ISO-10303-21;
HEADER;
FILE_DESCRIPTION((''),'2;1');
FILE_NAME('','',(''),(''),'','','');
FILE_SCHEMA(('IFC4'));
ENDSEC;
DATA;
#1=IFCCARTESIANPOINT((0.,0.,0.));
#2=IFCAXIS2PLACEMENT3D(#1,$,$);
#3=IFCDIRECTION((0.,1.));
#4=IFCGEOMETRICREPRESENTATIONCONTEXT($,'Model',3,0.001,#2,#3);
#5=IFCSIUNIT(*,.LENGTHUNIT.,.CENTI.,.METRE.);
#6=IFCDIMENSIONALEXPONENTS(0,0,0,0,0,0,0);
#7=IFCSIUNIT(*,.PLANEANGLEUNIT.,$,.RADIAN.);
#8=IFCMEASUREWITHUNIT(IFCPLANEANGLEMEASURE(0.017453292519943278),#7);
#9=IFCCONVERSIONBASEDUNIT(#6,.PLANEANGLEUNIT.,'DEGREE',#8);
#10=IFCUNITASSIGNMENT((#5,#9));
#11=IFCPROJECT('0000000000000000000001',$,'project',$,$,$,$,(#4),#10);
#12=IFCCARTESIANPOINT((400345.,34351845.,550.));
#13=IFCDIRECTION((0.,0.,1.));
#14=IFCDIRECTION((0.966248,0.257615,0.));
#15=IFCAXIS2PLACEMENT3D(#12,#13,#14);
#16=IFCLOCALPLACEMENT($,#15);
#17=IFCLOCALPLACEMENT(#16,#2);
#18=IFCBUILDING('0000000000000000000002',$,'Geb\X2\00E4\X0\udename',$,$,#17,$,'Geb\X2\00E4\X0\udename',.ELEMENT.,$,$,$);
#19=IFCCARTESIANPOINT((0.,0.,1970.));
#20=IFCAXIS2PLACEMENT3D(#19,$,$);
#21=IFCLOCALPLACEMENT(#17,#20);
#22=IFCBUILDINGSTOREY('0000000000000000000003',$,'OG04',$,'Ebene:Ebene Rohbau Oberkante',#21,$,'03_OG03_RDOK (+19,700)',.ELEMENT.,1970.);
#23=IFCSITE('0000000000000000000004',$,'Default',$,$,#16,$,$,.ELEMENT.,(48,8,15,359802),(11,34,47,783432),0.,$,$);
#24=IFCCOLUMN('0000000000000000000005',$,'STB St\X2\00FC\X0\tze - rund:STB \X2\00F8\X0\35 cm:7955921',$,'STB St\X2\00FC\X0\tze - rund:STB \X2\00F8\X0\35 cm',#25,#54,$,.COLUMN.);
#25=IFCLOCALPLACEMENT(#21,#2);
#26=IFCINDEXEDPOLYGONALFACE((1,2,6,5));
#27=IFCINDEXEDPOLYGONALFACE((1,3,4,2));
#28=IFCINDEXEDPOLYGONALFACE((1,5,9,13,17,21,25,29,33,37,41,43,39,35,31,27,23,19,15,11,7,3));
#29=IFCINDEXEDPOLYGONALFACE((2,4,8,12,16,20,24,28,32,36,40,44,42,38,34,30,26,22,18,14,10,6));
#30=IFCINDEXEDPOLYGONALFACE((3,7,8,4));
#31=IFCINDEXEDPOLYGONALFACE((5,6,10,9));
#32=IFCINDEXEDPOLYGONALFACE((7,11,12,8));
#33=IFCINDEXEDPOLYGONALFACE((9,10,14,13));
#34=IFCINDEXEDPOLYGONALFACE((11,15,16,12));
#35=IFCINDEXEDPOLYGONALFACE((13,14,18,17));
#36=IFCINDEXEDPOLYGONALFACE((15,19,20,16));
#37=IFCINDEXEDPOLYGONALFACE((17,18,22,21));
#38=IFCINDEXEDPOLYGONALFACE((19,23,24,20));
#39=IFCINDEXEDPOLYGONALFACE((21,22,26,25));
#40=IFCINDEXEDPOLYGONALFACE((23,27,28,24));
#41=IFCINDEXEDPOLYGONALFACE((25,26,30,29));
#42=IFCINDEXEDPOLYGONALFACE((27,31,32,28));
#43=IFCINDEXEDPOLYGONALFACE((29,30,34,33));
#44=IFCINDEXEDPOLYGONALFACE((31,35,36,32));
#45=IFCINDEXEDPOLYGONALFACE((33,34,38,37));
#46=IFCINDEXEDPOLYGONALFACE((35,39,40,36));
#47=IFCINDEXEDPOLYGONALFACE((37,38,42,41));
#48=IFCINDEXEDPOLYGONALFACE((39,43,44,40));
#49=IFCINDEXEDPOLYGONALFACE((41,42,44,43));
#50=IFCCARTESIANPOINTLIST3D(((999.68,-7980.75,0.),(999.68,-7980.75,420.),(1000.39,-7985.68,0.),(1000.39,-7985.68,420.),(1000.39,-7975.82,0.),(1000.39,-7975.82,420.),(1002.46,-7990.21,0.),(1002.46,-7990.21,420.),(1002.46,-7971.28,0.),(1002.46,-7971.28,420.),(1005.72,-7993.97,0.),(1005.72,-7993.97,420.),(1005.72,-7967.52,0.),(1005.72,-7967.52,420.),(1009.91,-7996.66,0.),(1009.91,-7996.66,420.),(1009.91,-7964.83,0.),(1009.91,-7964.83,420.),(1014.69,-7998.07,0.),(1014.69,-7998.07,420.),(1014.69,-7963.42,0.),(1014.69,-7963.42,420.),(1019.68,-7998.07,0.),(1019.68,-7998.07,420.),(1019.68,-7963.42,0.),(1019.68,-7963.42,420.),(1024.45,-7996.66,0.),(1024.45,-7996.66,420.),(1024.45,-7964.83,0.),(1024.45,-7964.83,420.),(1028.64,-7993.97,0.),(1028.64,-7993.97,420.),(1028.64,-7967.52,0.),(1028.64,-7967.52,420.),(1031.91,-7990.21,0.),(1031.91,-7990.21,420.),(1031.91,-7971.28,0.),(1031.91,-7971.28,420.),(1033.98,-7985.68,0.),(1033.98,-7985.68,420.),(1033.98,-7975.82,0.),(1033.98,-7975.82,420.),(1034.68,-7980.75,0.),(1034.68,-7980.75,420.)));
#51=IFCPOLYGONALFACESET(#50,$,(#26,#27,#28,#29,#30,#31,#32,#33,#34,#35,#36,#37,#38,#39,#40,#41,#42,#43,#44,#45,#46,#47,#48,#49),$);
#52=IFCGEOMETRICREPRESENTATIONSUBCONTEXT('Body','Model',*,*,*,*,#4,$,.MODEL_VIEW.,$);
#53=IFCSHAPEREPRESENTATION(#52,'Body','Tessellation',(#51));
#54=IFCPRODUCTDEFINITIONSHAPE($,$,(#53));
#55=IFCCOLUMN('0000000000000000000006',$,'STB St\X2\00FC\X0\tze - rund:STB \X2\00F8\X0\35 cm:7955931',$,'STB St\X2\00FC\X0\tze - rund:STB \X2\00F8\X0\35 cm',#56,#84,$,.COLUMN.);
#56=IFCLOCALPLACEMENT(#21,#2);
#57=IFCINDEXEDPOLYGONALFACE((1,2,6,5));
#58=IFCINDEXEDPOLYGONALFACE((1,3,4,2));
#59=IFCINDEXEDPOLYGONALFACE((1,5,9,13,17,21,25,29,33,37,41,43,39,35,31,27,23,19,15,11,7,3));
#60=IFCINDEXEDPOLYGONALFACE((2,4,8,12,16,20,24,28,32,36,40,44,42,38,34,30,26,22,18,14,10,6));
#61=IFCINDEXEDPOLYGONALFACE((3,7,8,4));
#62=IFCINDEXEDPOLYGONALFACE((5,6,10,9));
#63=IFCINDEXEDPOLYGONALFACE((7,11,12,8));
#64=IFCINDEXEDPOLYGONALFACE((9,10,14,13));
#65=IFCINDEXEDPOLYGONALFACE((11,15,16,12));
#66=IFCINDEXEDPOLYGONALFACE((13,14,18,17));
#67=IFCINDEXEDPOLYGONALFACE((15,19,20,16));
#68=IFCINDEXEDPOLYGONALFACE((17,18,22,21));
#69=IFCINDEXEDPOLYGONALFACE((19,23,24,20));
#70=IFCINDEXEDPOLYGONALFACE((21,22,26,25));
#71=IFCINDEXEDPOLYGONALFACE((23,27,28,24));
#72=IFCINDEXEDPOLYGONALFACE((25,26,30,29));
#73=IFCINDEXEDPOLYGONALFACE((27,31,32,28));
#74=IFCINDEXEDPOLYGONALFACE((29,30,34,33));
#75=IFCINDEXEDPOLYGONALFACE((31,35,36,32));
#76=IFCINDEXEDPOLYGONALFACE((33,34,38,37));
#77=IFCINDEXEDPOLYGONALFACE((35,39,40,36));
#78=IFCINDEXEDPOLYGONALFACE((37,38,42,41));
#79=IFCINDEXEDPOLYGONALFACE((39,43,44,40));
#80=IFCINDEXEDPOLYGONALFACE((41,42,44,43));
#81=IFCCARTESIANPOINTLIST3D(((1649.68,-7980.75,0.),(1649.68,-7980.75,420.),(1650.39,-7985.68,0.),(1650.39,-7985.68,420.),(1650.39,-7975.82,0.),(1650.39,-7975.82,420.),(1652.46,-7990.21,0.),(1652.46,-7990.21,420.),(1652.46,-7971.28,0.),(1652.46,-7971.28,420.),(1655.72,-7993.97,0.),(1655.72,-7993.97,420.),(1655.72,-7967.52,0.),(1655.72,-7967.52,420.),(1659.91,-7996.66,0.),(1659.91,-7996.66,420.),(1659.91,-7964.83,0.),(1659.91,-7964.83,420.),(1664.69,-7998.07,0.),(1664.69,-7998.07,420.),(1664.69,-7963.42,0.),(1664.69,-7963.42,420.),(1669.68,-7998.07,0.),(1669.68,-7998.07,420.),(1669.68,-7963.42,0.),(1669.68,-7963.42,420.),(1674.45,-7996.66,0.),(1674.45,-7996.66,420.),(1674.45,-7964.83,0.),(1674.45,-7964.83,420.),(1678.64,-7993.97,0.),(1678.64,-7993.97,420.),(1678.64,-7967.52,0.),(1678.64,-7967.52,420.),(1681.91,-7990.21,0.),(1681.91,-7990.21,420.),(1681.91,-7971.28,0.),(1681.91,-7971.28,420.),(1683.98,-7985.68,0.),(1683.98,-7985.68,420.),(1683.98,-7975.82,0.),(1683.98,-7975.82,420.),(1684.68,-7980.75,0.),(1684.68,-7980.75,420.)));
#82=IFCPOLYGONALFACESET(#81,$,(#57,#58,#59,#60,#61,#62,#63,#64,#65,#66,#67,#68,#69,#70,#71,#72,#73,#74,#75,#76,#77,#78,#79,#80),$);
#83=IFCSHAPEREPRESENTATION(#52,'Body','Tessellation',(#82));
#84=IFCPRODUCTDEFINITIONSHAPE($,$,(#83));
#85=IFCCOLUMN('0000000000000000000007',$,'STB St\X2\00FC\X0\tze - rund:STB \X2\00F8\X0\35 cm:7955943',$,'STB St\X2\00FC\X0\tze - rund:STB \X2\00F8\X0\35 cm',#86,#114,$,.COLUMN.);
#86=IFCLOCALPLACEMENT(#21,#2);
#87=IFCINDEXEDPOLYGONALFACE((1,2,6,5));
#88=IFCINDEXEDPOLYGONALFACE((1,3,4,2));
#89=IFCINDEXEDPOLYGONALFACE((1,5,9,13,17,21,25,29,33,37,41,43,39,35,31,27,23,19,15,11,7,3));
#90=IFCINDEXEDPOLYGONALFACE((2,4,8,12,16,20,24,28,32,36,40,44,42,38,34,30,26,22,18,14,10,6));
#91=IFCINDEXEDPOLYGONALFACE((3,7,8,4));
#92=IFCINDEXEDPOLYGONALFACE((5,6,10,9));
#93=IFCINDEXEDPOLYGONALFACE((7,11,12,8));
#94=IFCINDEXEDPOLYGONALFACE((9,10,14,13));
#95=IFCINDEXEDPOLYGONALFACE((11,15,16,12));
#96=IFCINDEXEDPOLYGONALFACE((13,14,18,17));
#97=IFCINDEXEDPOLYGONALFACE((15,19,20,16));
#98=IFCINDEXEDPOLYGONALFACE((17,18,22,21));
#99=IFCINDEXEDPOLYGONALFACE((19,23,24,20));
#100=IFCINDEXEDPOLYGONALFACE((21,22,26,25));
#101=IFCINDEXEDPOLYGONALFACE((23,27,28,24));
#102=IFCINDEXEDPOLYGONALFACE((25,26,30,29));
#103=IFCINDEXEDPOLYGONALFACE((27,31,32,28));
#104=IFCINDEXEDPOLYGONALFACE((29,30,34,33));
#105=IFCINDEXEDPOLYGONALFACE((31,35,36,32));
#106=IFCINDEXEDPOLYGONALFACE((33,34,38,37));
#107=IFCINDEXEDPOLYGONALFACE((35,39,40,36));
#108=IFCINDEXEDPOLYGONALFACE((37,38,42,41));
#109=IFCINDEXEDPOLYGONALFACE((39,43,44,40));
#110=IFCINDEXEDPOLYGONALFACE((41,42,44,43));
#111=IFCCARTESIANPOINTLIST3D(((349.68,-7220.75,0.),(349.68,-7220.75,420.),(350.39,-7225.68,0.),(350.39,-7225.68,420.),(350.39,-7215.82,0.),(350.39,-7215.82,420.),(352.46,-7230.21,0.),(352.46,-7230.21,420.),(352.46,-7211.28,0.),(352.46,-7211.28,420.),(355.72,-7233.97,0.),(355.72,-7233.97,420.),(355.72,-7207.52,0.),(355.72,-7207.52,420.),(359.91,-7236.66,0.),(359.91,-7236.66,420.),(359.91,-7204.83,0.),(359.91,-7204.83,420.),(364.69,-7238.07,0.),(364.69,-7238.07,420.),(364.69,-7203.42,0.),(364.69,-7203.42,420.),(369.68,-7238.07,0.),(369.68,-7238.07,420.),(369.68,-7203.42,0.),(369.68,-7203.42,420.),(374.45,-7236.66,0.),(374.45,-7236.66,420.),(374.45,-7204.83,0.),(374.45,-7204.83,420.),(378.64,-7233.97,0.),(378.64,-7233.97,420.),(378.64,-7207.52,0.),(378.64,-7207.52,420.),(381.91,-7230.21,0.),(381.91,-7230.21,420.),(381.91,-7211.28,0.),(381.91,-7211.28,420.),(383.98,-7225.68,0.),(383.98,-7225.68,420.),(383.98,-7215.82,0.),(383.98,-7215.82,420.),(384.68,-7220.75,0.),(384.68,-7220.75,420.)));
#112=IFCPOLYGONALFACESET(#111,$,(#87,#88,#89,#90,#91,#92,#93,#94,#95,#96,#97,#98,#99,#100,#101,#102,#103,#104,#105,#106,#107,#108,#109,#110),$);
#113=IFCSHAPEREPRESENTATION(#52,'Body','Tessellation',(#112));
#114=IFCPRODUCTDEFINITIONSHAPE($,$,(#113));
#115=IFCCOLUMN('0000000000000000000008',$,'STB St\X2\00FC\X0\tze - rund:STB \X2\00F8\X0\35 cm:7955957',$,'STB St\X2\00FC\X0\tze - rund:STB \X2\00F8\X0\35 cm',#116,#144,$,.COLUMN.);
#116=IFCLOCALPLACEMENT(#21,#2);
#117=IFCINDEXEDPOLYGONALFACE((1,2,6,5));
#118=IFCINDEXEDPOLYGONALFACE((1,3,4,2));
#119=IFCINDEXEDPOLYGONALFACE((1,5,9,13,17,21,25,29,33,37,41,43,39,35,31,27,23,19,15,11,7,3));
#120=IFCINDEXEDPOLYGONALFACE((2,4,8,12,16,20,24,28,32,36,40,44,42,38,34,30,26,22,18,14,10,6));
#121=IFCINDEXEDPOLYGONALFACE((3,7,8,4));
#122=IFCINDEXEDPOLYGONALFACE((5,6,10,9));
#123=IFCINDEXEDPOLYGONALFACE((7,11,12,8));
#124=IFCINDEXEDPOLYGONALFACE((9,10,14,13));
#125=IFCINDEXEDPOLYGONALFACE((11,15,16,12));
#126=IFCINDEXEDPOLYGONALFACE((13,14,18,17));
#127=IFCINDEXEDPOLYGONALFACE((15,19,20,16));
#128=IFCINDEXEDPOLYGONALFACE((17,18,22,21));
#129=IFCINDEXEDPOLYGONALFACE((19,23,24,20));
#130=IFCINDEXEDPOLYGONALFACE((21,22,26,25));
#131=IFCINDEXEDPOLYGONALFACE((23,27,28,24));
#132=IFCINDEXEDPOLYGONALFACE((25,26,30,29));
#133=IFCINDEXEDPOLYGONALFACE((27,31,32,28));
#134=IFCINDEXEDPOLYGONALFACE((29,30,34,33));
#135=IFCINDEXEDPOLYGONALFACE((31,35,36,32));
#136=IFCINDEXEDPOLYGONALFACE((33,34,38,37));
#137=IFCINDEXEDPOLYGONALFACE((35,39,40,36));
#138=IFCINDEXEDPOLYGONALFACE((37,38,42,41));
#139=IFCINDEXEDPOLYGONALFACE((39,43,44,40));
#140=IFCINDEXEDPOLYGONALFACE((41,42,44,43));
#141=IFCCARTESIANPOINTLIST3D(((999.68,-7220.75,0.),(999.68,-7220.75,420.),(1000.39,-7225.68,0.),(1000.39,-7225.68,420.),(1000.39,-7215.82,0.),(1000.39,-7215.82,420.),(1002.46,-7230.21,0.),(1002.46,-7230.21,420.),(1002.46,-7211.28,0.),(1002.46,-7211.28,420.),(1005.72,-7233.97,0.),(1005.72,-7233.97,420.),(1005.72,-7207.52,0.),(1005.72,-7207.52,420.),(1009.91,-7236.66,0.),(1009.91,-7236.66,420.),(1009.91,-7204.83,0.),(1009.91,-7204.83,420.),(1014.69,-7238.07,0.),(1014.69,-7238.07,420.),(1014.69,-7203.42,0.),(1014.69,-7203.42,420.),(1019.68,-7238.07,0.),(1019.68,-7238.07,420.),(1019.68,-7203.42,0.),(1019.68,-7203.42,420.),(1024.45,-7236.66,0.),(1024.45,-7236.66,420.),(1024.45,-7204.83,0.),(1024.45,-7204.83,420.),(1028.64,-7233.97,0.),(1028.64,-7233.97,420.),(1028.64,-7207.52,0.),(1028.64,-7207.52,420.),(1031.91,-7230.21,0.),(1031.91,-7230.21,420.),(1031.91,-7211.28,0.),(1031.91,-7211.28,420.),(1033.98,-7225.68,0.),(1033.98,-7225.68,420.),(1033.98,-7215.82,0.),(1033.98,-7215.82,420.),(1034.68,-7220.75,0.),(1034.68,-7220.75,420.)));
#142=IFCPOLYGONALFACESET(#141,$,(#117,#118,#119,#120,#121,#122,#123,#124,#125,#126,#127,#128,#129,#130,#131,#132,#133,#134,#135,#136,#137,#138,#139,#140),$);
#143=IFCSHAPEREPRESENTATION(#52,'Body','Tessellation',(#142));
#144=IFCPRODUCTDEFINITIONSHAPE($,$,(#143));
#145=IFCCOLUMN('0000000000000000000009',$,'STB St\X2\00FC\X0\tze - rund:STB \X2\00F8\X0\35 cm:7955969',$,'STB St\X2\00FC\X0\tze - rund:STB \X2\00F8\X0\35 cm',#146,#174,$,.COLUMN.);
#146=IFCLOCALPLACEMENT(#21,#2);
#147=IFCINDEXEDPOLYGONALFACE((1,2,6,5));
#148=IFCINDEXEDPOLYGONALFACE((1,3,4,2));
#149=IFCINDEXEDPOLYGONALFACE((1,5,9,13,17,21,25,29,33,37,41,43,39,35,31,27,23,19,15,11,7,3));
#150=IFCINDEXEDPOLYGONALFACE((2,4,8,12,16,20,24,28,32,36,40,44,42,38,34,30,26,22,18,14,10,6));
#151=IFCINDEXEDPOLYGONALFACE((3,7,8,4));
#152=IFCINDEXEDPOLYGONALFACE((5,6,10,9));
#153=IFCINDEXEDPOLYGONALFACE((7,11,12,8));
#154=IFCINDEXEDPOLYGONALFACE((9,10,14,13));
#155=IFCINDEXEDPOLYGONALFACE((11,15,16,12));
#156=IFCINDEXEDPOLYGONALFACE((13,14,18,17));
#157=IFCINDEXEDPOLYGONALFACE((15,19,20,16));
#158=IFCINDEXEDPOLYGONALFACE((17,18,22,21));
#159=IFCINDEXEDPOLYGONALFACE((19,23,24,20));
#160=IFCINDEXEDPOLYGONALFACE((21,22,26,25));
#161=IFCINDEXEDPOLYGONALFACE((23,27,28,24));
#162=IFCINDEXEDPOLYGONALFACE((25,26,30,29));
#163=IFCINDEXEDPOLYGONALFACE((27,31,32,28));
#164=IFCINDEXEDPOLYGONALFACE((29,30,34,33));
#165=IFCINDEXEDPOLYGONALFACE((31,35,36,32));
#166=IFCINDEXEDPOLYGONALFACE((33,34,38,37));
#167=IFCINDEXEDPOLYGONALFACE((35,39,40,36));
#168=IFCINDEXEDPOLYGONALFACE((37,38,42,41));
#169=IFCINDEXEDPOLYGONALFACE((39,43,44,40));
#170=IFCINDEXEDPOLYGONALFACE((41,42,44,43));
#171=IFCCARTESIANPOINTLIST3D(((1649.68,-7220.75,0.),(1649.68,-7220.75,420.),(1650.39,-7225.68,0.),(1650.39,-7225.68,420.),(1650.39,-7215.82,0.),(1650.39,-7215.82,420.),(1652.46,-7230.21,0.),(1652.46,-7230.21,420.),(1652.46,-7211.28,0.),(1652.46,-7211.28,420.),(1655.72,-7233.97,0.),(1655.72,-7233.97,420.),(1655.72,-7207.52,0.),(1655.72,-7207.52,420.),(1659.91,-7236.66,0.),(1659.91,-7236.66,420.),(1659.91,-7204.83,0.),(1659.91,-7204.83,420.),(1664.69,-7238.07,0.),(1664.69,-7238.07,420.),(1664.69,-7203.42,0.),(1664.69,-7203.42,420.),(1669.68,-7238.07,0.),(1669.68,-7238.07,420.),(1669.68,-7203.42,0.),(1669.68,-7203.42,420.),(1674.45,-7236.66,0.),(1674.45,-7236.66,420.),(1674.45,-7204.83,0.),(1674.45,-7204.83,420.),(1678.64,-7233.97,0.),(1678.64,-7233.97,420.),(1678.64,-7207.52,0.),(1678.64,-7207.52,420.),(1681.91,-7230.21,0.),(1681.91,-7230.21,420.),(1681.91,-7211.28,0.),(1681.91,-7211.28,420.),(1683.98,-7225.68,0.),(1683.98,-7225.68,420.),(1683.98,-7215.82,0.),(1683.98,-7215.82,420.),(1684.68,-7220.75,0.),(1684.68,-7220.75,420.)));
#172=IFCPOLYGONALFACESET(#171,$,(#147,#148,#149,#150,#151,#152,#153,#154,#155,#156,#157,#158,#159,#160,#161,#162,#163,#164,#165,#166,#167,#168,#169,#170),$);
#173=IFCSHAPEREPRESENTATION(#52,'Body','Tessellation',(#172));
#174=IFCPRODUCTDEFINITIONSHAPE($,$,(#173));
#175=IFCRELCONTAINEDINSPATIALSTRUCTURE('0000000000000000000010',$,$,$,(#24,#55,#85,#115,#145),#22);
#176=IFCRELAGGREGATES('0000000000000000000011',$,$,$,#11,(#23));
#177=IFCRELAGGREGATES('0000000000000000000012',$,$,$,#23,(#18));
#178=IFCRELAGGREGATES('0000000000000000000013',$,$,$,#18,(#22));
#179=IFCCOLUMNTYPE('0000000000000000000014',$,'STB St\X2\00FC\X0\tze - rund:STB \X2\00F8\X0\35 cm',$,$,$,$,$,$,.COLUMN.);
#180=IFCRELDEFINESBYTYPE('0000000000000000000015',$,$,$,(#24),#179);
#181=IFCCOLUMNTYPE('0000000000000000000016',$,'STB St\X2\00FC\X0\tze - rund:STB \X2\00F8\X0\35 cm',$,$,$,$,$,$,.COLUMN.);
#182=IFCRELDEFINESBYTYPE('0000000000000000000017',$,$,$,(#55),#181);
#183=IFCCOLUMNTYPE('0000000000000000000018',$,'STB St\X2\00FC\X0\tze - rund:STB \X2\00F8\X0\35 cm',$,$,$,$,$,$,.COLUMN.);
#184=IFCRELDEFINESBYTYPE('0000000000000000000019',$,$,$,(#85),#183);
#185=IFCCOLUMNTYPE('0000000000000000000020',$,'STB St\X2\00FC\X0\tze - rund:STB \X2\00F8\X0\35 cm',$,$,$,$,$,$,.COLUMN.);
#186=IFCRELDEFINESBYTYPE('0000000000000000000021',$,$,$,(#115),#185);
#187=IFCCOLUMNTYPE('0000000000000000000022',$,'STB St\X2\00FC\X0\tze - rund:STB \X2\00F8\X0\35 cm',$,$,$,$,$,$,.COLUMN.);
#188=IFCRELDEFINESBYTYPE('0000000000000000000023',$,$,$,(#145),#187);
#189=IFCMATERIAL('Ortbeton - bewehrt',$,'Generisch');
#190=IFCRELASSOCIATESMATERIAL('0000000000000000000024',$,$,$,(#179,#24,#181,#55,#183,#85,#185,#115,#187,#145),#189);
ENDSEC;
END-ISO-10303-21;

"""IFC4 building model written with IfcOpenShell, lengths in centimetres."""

from ifc_helpers import new_model, entity, si_unit, converted_unit, direction, frame, origin, place, context, subcontext, project, spatial, arc, indexed_curve, outline, extrude, source, transform, mapped, material, type_object, type_shapes, element, save


model = new_model("IFC4")

# Units and contexts
model_context = context("Model", 3, precision=0.001, world=origin(), true_north=direction((0.0, 1.0)))
body_context = subcontext(model_context, "Body", "Model", "MODEL_VIEW")
ifc_project = project(units=[si_unit("LENGTHUNIT", "METRE", prefix="CENTI"), converted_unit("PLANEANGLEUNIT", "DEGREE", entity("IfcPlaneAngleMeasure", 0.017453292519943278), si_unit("PLANEANGLEUNIT", "RADIAN"), dimensions=[0, 0, 0, 0, 0, 0, 0])], contexts=[model_context])

# Site, building, storey
site_placement = place(None, frame((400345.0, 34351845.0, 550.0), z_axis=(0.0, 0.0, 1.0), x_axis=(0.966248, 0.257615, 0.0)))
site = spatial("IfcSite", under=ifc_project, at=site_placement, Name="Default", CompositionType="ELEMENT", RefLatitude=(48, 8, 15, 359802), RefLongitude=(11, 34, 47, 783432), RefElevation=0.0)
building_placement = place(site_placement, origin())
building = spatial("IfcBuilding", under=site, at=building_placement, Name="Gebäudename", LongName="Gebäudename", CompositionType="ELEMENT")
storey_placement = place(building_placement, frame((0.0, 0.0, 1970.0)))
storey = spatial("IfcBuildingStorey", under=building, at=storey_placement, Name="OG04", ObjectType="Ebene:Ebene Rohbau Oberkante", LongName="03_OG03_RDOK (+19,700)", CompositionType="ELEMENT", Elevation=1970.0)

# Columns
ifc_material = material(Name="Ortbeton - bewehrt", Category="Generisch")
column_type_1 = type_object("IfcColumnType", Name="STB Stütze - rund:STB ø35 cm", PredefinedType="COLUMN", material=ifc_material)
shared_shape_1 = source(origin(), body_context, "Body", "SweptSolid", [
    extrude(outline(indexed_curve([(-17.5, 0.0), (0.0, -17.5), (17.5, 0.0), (0.0, 17.5)], segments=[arc(1, 2, 3), arc(3, 4, 1)], self_intersect=False)), frame((1017.18, -7980.75, 1970.0)), (0.0, 0.0, 1.0), 420.0),
])
type_shapes(column_type_1, [shared_shape_1])
column_1_placement = place(storey_placement, frame((0.0, 0.0, -1970.0)))
element("IfcColumn", 1, at=column_1_placement, inside=storey, type_object=column_type_1, material=ifc_material, Name="STB Stütze - rund:STB ø35 cm:7955921", ObjectType="STB Stütze - rund:STB ø35 cm", PredefinedType="COLUMN", context=body_context, shape_type="MappedRepresentation", body=[
    mapped(shared_shape_1, transform((0.0, 0.0, 0.0), scale=1.0)),
])
column_type_2 = type_object("IfcColumnType", Name="STB Stütze - rund:STB ø35 cm", PredefinedType="COLUMN", material=ifc_material)
shared_shape_2 = source(origin(), body_context, "Body", "SweptSolid", [
    extrude(outline(indexed_curve([(-17.5, 0.0), (0.0, -17.5), (17.5, 0.0), (0.0, 17.5)], segments=[arc(1, 2, 3), arc(3, 4, 1)], self_intersect=False)), frame((1667.18, -7980.75, 1970.0)), (0.0, 0.0, 1.0), 420.0),
])
type_shapes(column_type_2, [shared_shape_2])
column_2_placement = place(storey_placement, frame((0.0, 0.0, -1970.0)))
element("IfcColumn", 2, at=column_2_placement, inside=storey, type_object=column_type_2, material=ifc_material, Name="STB Stütze - rund:STB ø35 cm:7955931", ObjectType="STB Stütze - rund:STB ø35 cm", PredefinedType="COLUMN", context=body_context, shape_type="MappedRepresentation", body=[
    mapped(shared_shape_2, transform((0.0, 0.0, 0.0), scale=1.0)),
])
column_type_3 = type_object("IfcColumnType", Name="STB Stütze - rund:STB ø35 cm", PredefinedType="COLUMN", material=ifc_material)
shared_shape_3 = source(origin(), body_context, "Body", "SweptSolid", [
    extrude(outline(indexed_curve([(-17.5, 0.0), (0.0, -17.5), (17.5, 0.0), (0.0, 17.5)], segments=[arc(1, 2, 3), arc(3, 4, 1)], self_intersect=False)), frame((367.18, -7220.75, 1970.0)), (0.0, 0.0, 1.0), 420.0),
])
type_shapes(column_type_3, [shared_shape_3])
column_3_placement = place(storey_placement, frame((0.0, 0.0, -1970.0)))
element("IfcColumn", 3, at=column_3_placement, inside=storey, type_object=column_type_3, material=ifc_material, Name="STB Stütze - rund:STB ø35 cm:7955943", ObjectType="STB Stütze - rund:STB ø35 cm", PredefinedType="COLUMN", context=body_context, shape_type="MappedRepresentation", body=[
    mapped(shared_shape_3, transform((0.0, 0.0, 0.0), scale=1.0)),
])
column_type_4 = type_object("IfcColumnType", Name="STB Stütze - rund:STB ø35 cm", PredefinedType="COLUMN", material=ifc_material)
shared_shape_4 = source(origin(), body_context, "Body", "SweptSolid", [
    extrude(outline(indexed_curve([(-17.5, 0.0), (0.0, -17.5), (17.5, 0.0), (0.0, 17.5)], segments=[arc(1, 2, 3), arc(3, 4, 1)], self_intersect=False)), frame((1017.18, -7220.75, 1970.0)), (0.0, 0.0, 1.0), 420.0),
])
type_shapes(column_type_4, [shared_shape_4])
column_4_placement = place(storey_placement, frame((0.0, 0.0, -1970.0)))
element("IfcColumn", 4, at=column_4_placement, inside=storey, type_object=column_type_4, material=ifc_material, Name="STB Stütze - rund:STB ø35 cm:7955957", ObjectType="STB Stütze - rund:STB ø35 cm", PredefinedType="COLUMN", context=body_context, shape_type="MappedRepresentation", body=[
    mapped(shared_shape_4, transform((0.0, 0.0, 0.0), scale=1.0)),
])
column_type_5 = type_object("IfcColumnType", Name="STB Stütze - rund:STB ø35 cm", PredefinedType="COLUMN", material=ifc_material)
shared_shape_5 = source(origin(), body_context, "Body", "SweptSolid", [
    extrude(outline(indexed_curve([(-17.5, 0.0), (0.0, -17.5), (17.5, 0.0), (0.0, 17.5)], segments=[arc(1, 2, 3), arc(3, 4, 1)], self_intersect=False)), frame((1667.18, -7220.75, 1970.0)), (0.0, 0.0, 1.0), 420.0),
])
type_shapes(column_type_5, [shared_shape_5])
column_5_placement = place(storey_placement, frame((0.0, 0.0, -1970.0)))
element("IfcColumn", 5, at=column_5_placement, inside=storey, type_object=column_type_5, material=ifc_material, Name="STB Stütze - rund:STB ø35 cm:7955969", ObjectType="STB Stütze - rund:STB ø35 cm", PredefinedType="COLUMN", context=body_context, shape_type="MappedRepresentation", body=[
    mapped(shared_shape_5, transform((0.0, 0.0, 0.0), scale=1.0)),
])

save(model, "model.ifc")
